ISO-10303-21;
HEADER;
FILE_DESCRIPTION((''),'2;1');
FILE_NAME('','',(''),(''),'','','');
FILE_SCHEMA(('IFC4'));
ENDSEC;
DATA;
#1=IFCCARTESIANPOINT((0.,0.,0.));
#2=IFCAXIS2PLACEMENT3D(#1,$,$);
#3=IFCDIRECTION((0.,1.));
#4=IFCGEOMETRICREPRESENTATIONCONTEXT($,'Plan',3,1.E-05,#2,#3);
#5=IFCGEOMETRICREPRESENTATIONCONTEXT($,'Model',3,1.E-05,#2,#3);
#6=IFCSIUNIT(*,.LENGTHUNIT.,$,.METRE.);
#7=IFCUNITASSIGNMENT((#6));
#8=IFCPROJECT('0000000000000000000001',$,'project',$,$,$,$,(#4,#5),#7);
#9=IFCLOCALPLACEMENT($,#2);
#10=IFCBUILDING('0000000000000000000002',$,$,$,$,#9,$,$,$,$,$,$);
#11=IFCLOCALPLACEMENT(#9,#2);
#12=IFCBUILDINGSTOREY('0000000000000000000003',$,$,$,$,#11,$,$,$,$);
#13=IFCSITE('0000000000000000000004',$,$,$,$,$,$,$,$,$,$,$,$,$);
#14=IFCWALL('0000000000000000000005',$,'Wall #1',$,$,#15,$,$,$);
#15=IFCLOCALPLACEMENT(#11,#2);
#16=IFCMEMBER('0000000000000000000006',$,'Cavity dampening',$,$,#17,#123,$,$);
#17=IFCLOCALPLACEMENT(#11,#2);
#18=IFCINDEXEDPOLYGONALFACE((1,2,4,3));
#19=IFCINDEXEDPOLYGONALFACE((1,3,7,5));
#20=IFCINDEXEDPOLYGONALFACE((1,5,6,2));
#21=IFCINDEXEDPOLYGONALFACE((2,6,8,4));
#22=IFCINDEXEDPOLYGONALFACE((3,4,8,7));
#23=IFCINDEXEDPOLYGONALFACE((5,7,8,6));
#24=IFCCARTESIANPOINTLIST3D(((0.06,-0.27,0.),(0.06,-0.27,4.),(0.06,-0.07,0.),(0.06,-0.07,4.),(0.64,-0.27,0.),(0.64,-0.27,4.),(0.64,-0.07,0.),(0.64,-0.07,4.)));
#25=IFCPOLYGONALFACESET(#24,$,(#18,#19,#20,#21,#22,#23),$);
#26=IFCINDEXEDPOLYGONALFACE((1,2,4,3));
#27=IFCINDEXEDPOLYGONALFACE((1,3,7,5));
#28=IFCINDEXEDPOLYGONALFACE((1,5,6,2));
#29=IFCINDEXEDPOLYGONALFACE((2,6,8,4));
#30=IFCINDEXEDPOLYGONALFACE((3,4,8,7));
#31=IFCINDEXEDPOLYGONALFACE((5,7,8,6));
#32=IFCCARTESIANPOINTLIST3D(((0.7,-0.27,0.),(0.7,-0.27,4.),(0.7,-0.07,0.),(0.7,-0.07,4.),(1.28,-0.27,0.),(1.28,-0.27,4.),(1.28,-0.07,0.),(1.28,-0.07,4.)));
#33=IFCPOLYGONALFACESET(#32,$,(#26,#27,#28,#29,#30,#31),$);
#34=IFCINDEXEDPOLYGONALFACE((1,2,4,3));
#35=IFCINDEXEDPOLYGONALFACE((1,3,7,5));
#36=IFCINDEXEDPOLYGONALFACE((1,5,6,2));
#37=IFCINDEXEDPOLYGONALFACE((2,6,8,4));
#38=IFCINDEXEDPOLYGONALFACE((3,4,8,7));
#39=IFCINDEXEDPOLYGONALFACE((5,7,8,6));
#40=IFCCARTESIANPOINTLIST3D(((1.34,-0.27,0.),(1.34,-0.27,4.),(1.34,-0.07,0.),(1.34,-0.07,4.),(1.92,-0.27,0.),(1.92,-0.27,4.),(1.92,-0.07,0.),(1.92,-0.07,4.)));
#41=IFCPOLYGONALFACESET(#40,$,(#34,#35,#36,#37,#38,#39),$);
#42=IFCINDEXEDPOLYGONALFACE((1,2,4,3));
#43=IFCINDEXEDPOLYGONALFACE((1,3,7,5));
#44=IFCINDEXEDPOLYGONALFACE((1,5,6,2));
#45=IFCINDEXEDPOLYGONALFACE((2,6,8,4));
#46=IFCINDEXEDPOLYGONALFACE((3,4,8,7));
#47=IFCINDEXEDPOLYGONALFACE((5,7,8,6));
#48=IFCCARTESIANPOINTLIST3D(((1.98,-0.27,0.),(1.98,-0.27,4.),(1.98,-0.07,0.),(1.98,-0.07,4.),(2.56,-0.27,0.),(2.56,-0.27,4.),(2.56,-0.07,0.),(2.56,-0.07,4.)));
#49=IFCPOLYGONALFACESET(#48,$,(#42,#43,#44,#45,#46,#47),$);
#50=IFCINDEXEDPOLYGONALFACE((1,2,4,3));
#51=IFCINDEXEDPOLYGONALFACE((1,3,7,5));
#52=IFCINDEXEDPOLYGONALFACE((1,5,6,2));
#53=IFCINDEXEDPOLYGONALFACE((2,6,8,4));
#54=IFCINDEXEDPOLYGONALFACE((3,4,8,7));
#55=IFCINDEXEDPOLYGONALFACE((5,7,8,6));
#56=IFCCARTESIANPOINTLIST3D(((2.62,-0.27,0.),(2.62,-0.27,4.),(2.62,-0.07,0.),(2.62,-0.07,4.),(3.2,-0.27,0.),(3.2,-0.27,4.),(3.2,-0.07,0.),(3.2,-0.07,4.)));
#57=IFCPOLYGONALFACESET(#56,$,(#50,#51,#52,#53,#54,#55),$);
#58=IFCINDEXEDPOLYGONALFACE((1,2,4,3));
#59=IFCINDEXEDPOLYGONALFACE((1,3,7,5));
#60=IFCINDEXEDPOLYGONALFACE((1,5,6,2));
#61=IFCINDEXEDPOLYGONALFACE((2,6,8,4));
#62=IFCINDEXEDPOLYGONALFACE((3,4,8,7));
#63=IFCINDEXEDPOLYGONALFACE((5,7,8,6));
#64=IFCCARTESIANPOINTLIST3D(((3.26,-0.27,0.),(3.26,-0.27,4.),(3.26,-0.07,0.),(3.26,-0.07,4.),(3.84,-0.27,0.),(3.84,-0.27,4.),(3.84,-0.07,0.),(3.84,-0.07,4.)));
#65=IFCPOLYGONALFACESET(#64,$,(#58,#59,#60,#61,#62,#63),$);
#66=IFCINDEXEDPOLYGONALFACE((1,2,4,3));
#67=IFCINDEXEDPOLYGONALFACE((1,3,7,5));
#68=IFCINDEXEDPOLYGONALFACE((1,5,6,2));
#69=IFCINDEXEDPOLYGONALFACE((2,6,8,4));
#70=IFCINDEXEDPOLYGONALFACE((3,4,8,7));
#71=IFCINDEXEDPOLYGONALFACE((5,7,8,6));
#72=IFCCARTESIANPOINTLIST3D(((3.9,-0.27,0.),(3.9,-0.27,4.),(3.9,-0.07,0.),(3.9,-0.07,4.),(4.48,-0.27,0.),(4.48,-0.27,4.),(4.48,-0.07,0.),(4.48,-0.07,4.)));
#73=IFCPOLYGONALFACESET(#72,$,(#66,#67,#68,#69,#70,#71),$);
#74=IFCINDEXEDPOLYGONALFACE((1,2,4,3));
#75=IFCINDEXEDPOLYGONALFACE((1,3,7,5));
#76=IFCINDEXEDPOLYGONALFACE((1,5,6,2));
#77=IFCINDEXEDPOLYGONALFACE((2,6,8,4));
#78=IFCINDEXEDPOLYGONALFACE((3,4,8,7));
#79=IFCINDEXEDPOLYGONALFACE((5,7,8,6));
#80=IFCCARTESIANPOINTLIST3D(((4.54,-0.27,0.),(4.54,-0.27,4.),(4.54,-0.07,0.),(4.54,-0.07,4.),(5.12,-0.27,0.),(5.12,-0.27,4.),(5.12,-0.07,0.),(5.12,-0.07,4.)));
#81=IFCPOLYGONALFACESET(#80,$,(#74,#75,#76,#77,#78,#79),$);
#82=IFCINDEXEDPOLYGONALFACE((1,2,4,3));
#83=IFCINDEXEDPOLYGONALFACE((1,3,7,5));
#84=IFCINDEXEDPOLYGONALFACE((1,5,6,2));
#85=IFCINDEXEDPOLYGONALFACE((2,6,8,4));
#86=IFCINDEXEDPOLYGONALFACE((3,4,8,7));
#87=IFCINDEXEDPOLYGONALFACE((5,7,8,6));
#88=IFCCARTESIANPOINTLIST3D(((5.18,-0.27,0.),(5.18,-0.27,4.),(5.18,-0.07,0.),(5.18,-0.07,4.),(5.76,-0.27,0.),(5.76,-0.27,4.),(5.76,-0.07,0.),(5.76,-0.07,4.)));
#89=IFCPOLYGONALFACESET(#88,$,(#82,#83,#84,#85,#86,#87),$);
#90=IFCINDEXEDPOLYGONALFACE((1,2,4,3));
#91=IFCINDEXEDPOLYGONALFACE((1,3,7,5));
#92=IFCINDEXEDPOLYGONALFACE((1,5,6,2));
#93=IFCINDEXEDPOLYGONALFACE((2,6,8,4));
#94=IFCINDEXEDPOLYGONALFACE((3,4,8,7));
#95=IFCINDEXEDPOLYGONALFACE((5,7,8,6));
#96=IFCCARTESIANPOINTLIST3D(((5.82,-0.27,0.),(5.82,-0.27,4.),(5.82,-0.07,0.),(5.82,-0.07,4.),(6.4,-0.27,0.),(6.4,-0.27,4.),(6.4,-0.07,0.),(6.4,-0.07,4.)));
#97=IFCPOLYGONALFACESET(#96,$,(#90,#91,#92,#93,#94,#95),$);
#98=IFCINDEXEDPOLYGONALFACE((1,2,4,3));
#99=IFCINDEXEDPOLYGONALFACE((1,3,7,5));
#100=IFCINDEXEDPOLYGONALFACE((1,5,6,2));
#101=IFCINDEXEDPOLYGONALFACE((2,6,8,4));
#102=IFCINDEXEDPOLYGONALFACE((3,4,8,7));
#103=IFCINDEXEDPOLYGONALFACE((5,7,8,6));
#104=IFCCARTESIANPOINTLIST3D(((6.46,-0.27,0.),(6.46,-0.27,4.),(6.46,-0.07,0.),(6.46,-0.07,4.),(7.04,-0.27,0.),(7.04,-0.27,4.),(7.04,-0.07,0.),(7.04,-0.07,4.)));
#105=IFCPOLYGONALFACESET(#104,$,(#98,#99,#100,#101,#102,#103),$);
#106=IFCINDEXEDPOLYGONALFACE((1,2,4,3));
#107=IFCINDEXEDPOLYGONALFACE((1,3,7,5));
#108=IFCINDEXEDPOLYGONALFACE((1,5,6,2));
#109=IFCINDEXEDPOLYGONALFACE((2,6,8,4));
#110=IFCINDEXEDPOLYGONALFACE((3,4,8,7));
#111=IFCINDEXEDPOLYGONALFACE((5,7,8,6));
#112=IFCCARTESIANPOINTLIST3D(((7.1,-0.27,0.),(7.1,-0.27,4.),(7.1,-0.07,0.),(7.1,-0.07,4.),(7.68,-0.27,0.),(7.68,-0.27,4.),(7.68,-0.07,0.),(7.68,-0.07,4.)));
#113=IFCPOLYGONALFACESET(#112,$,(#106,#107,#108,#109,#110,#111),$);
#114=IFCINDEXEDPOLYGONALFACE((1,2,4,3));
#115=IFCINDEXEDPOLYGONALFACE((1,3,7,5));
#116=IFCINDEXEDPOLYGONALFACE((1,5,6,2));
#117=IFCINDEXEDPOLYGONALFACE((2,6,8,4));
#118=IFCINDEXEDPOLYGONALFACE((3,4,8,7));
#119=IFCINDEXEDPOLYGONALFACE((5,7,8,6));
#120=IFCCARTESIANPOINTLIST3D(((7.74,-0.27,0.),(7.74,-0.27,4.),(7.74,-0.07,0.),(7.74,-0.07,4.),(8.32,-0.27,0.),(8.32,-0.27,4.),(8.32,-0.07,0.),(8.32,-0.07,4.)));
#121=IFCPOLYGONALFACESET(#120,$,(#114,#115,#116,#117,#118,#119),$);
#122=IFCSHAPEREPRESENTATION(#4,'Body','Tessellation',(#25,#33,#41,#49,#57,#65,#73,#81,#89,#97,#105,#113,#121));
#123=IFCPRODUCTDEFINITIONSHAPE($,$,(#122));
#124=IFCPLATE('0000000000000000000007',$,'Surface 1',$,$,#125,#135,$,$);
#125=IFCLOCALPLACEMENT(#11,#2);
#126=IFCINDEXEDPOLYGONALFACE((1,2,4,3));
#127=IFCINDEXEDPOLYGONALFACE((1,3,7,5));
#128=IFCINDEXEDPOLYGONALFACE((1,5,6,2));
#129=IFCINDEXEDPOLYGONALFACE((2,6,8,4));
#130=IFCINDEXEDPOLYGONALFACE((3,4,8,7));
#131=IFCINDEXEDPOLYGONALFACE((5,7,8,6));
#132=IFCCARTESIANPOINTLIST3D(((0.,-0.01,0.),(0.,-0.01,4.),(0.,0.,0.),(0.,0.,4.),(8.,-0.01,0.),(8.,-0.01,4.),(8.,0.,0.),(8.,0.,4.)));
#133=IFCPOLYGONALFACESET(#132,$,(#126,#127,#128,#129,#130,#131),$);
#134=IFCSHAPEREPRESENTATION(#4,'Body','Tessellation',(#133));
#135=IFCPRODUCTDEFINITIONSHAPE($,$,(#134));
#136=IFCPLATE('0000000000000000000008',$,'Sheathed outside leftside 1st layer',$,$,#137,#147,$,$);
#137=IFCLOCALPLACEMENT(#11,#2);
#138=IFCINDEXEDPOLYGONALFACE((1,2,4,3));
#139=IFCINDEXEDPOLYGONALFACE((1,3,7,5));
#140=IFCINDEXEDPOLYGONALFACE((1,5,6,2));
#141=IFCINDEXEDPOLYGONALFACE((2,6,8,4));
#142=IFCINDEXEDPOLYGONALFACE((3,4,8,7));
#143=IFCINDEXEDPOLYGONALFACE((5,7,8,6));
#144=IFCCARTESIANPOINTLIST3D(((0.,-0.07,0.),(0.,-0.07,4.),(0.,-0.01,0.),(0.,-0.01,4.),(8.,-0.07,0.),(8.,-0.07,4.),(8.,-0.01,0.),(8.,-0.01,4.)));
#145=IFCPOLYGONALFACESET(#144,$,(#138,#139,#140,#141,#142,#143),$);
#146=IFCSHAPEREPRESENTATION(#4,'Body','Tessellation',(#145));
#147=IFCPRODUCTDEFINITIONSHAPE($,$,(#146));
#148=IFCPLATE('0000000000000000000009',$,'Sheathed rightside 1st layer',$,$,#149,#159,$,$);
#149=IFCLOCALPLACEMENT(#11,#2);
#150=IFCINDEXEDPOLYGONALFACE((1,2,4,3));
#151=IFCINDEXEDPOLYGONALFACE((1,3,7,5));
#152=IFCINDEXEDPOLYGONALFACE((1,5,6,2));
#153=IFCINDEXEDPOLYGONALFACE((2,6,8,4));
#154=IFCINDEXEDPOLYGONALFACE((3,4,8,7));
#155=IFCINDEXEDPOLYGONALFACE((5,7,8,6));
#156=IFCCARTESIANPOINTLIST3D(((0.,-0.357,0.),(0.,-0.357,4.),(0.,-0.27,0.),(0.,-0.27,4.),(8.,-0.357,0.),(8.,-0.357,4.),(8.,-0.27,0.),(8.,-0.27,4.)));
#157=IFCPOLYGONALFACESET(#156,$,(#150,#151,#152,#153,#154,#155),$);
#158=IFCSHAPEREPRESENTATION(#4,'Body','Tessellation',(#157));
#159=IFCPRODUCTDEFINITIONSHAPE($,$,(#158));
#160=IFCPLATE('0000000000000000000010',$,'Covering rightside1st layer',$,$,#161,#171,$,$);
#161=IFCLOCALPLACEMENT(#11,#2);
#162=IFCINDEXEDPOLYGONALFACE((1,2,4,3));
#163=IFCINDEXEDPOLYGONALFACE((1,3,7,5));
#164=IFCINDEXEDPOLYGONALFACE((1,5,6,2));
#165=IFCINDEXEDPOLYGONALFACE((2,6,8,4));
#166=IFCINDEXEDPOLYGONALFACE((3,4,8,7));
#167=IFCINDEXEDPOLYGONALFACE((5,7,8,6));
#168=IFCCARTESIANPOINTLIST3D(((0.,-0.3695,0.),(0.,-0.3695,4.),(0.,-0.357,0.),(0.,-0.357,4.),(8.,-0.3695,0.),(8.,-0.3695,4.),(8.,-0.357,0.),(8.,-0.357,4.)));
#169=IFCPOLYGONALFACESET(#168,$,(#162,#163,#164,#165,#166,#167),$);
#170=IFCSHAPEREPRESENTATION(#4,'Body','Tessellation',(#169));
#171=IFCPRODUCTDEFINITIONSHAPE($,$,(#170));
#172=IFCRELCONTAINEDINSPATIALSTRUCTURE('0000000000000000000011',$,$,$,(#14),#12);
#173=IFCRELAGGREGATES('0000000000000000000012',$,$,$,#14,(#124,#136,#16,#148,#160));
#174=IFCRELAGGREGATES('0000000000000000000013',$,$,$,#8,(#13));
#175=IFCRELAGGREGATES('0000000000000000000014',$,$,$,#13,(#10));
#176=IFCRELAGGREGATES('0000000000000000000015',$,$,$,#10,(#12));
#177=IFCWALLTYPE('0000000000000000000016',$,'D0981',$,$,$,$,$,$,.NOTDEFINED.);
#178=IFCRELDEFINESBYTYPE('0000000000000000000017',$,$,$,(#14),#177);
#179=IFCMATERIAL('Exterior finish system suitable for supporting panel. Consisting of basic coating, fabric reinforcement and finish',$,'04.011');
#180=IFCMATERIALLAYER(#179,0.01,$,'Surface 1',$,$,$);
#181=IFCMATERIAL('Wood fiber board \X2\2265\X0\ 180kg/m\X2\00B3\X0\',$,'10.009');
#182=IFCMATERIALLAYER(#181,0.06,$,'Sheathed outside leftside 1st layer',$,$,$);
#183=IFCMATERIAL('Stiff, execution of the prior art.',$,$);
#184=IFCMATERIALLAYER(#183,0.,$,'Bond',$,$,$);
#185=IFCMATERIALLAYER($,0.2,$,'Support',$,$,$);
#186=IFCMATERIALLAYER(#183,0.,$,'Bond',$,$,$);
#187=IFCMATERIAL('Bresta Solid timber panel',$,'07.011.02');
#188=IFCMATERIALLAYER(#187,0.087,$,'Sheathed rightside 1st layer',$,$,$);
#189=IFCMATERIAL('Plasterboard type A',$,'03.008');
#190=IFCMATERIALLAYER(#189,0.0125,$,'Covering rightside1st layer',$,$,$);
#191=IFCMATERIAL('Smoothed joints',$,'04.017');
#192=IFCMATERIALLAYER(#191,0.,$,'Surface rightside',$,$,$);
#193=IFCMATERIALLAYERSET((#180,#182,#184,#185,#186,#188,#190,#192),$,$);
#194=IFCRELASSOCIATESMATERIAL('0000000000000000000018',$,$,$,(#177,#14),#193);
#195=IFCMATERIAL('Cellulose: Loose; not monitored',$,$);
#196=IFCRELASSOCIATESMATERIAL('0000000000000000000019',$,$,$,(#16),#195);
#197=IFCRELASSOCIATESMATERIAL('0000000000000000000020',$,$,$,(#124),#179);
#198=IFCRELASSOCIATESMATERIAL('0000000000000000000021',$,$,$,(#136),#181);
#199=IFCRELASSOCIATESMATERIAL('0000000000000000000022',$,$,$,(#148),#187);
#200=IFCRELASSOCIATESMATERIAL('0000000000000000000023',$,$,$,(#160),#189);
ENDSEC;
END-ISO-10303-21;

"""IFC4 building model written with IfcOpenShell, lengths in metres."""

from ifc_helpers import new_model, si_unit, direction, frame, frame_2d, origin, origin_with_axes, place, context, project, spatial, rectangle, extrude, material, layer, layer_set, type_object, element, aggregate, save


model = new_model("IFC4")

# Units and contexts
plan_context = context("Plan", 3, precision=1e-05, world=origin(), true_north=direction((0.0, 1.0)))
model_context = context("Model", 3, precision=1e-05, world=origin(), true_north=direction((0.0, 1.0)))
ifc_project = project(units=[si_unit("LENGTHUNIT", "METRE")], contexts=[plan_context, model_context])

# Site, building, storey
site = spatial("IfcSite", under=ifc_project)
building_placement = place(None, origin())
building = spatial("IfcBuilding", under=site, at=building_placement)
storey_placement = place(building_placement, origin())
storey = spatial("IfcBuildingStorey", under=building, at=storey_placement)

# Wall, member, plates
ifc_material_1 = material(Name="Exterior finish system suitable for supporting panel. Consisting of basic coating, fabric reinforcement and finish", Category="04.011")
ifc_layer_1 = layer(ifc_material_1, 0.01, Name="Surface 1")
ifc_material_2 = material(Name="Wood fiber board ≥ 180kg/m³", Category="10.009")
ifc_layer_2 = layer(ifc_material_2, 0.06, Name="Sheathed outside leftside 1st layer")
ifc_material_3 = material(Name="Stiff, execution of the prior art.")
ifc_layer_3 = layer(ifc_material_3, 0.0, Name="Bond")
ifc_layer_4 = layer(None, 0.2, Name="Support")
ifc_layer_5 = layer(ifc_material_3, 0.0, Name="Bond")
ifc_material_4 = material(Name="Bresta Solid timber panel", Category="07.011.02")
ifc_layer_6 = layer(ifc_material_4, 0.087, Name="Sheathed rightside 1st layer")
ifc_material_5 = material(Name="Plasterboard type A", Category="03.008")
ifc_layer_7 = layer(ifc_material_5, 0.0125, Name="Covering rightside1st layer")
ifc_material_6 = material(Name="Smoothed joints", Category="04.017")
ifc_layer_8 = layer(ifc_material_6, 0.0, Name="Surface rightside")
ifc_layer_set = layer_set([ifc_layer_1, ifc_layer_2, ifc_layer_3, ifc_layer_4, ifc_layer_5, ifc_layer_6, ifc_layer_7, ifc_layer_8])
wall_type = type_object("IfcWallType", Name="D0981", PredefinedType="NOTDEFINED", material=ifc_layer_set)
wall_placement = place(None, frame((0.0, 0.0, 0.0), z_axis=(0.0, -1.0, 0.0), x_axis=(1.0, 0.0, 0.0)))
wall = element("IfcWall", 1, at=wall_placement, inside=storey, type_object=wall_type, material=ifc_layer_set, Name="Wall #1")
ifc_material_7 = material(Name="Cellulose: Loose; not monitored")
member_1_placement = place(wall_placement, origin())
member_1 = element("IfcMember", 2, at=member_1_placement, material=ifc_material_7, Name="Cavity dampening", context=plan_context, shape_type="SweptSolid", body=[
    extrude(rectangle(XDim=0.58, YDim=0.2, at=frame_2d((0.29, 0.1), x_axis=(1.0, 0.0))), frame((0.06, 4.0, 0.07), z_axis=(0.0, -1.0, 0.0), x_axis=(1.0, 0.0, 0.0)), (0.0, 0.0, 1.0), 4.0),
    extrude(rectangle(XDim=0.58, YDim=0.2, at=frame_2d((0.29, 0.1), x_axis=(1.0, 0.0))), frame((0.7, 4.0, 0.07), z_axis=(0.0, -1.0, 0.0), x_axis=(1.0, 0.0, 0.0)), (0.0, 0.0, 1.0), 4.0),
    extrude(rectangle(XDim=0.58, YDim=0.2, at=frame_2d((0.29, 0.1), x_axis=(1.0, 0.0))), frame((1.34, 4.0, 0.07), z_axis=(0.0, -1.0, 0.0), x_axis=(1.0, 0.0, 0.0)), (0.0, 0.0, 1.0), 4.0),
    extrude(rectangle(XDim=0.58, YDim=0.2, at=frame_2d((0.29, 0.1), x_axis=(1.0, 0.0))), frame((1.98, 4.0, 0.07), z_axis=(0.0, -1.0, 0.0), x_axis=(1.0, 0.0, 0.0)), (0.0, 0.0, 1.0), 4.0),
    extrude(rectangle(XDim=0.58, YDim=0.2, at=frame_2d((0.29, 0.1), x_axis=(1.0, 0.0))), frame((2.62, 4.0, 0.07), z_axis=(0.0, -1.0, 0.0), x_axis=(1.0, 0.0, 0.0)), (0.0, 0.0, 1.0), 4.0),
    extrude(rectangle(XDim=0.58, YDim=0.2, at=frame_2d((0.29, 0.1), x_axis=(1.0, 0.0))), frame((3.26, 4.0, 0.07), z_axis=(0.0, -1.0, 0.0), x_axis=(1.0, 0.0, 0.0)), (0.0, 0.0, 1.0), 4.0),
    extrude(rectangle(XDim=0.58, YDim=0.2, at=frame_2d((0.29, 0.1), x_axis=(1.0, 0.0))), frame((3.9, 4.0, 0.07), z_axis=(0.0, -1.0, 0.0), x_axis=(1.0, 0.0, 0.0)), (0.0, 0.0, 1.0), 4.0),
    extrude(rectangle(XDim=0.58, YDim=0.2, at=frame_2d((0.29, 0.1), x_axis=(1.0, 0.0))), frame((4.54, 4.0, 0.07), z_axis=(0.0, -1.0, 0.0), x_axis=(1.0, 0.0, 0.0)), (0.0, 0.0, 1.0), 4.0),
    extrude(rectangle(XDim=0.58, YDim=0.2, at=frame_2d((0.29, 0.1), x_axis=(1.0, 0.0))), frame((5.18, 4.0, 0.07), z_axis=(0.0, -1.0, 0.0), x_axis=(1.0, 0.0, 0.0)), (0.0, 0.0, 1.0), 4.0),
    extrude(rectangle(XDim=0.58, YDim=0.2, at=frame_2d((0.29, 0.1), x_axis=(1.0, 0.0))), frame((5.82, 4.0, 0.07), z_axis=(0.0, -1.0, 0.0), x_axis=(1.0, 0.0, 0.0)), (0.0, 0.0, 1.0), 4.0),
    extrude(rectangle(XDim=0.58, YDim=0.2, at=frame_2d((0.29, 0.1), x_axis=(1.0, 0.0))), frame((6.46, 4.0, 0.07), z_axis=(0.0, -1.0, 0.0), x_axis=(1.0, 0.0, 0.0)), (0.0, 0.0, 1.0), 4.0),
    extrude(rectangle(XDim=0.58, YDim=0.2, at=frame_2d((0.29, 0.1), x_axis=(1.0, 0.0))), frame((7.1, 4.0, 0.07), z_axis=(0.0, -1.0, 0.0), x_axis=(1.0, 0.0, 0.0)), (0.0, 0.0, 1.0), 4.0),
    extrude(rectangle(XDim=0.58, YDim=0.2, at=frame_2d((0.29, 0.1), x_axis=(1.0, 0.0))), frame((7.74, 4.0, 0.07), z_axis=(0.0, -1.0, 0.0), x_axis=(1.0, 0.0, 0.0)), (0.0, 0.0, 1.0), 4.0),
])
plate_1_placement = place(wall_placement, origin())
plate_1 = element("IfcPlate", 3, at=plate_1_placement, material=ifc_material_1, Name="Surface 1", context=plan_context, shape_type="SweptSolid", body=[
    extrude(rectangle(XDim=8.0, YDim=4.0, at=frame_2d((4.0, 2.0), x_axis=(1.0, 0.0))), origin_with_axes(), (0.0, 0.0, 1.0), 0.01),
])
plate_2_placement = place(wall_placement, origin())
plate_2 = element("IfcPlate", 4, at=plate_2_placement, material=ifc_material_2, Name="Sheathed outside leftside 1st layer", context=plan_context, shape_type="SweptSolid", body=[
    extrude(rectangle(XDim=8.0, YDim=4.0, at=frame_2d((4.0, 2.0), x_axis=(1.0, 0.0))), frame((0.0, 0.0, 0.01), z_axis=(0.0, 0.0, 1.0), x_axis=(1.0, 0.0, 0.0)), (0.0, 0.0, 1.0), 0.06),
])
plate_3_placement = place(wall_placement, origin())
plate_3 = element("IfcPlate", 5, at=plate_3_placement, material=ifc_material_4, Name="Sheathed rightside 1st layer", context=plan_context, shape_type="SweptSolid", body=[
    extrude(rectangle(XDim=8.0, YDim=4.0, at=frame_2d((4.0, 2.0), x_axis=(1.0, 0.0))), frame((0.0, 0.0, 0.27), z_axis=(0.0, 0.0, 1.0), x_axis=(1.0, 0.0, 0.0)), (0.0, 0.0, 1.0), 0.087),
])
plate_4_placement = place(wall_placement, origin())
plate_4 = element("IfcPlate", 6, at=plate_4_placement, material=ifc_material_5, Name="Covering rightside1st layer", context=plan_context, shape_type="SweptSolid", body=[
    extrude(rectangle(XDim=8.0, YDim=4.0, at=frame_2d((4.0, 2.0), x_axis=(1.0, 0.0))), frame((0.0, 0.0, 0.357), z_axis=(0.0, 0.0, 1.0), x_axis=(1.0, 0.0, 0.0)), (0.0, 0.0, 1.0), 0.0125),
])
aggregate(wall, [plate_1, plate_2, member_1, plate_3, plate_4])

save(model, "model.ifc")
